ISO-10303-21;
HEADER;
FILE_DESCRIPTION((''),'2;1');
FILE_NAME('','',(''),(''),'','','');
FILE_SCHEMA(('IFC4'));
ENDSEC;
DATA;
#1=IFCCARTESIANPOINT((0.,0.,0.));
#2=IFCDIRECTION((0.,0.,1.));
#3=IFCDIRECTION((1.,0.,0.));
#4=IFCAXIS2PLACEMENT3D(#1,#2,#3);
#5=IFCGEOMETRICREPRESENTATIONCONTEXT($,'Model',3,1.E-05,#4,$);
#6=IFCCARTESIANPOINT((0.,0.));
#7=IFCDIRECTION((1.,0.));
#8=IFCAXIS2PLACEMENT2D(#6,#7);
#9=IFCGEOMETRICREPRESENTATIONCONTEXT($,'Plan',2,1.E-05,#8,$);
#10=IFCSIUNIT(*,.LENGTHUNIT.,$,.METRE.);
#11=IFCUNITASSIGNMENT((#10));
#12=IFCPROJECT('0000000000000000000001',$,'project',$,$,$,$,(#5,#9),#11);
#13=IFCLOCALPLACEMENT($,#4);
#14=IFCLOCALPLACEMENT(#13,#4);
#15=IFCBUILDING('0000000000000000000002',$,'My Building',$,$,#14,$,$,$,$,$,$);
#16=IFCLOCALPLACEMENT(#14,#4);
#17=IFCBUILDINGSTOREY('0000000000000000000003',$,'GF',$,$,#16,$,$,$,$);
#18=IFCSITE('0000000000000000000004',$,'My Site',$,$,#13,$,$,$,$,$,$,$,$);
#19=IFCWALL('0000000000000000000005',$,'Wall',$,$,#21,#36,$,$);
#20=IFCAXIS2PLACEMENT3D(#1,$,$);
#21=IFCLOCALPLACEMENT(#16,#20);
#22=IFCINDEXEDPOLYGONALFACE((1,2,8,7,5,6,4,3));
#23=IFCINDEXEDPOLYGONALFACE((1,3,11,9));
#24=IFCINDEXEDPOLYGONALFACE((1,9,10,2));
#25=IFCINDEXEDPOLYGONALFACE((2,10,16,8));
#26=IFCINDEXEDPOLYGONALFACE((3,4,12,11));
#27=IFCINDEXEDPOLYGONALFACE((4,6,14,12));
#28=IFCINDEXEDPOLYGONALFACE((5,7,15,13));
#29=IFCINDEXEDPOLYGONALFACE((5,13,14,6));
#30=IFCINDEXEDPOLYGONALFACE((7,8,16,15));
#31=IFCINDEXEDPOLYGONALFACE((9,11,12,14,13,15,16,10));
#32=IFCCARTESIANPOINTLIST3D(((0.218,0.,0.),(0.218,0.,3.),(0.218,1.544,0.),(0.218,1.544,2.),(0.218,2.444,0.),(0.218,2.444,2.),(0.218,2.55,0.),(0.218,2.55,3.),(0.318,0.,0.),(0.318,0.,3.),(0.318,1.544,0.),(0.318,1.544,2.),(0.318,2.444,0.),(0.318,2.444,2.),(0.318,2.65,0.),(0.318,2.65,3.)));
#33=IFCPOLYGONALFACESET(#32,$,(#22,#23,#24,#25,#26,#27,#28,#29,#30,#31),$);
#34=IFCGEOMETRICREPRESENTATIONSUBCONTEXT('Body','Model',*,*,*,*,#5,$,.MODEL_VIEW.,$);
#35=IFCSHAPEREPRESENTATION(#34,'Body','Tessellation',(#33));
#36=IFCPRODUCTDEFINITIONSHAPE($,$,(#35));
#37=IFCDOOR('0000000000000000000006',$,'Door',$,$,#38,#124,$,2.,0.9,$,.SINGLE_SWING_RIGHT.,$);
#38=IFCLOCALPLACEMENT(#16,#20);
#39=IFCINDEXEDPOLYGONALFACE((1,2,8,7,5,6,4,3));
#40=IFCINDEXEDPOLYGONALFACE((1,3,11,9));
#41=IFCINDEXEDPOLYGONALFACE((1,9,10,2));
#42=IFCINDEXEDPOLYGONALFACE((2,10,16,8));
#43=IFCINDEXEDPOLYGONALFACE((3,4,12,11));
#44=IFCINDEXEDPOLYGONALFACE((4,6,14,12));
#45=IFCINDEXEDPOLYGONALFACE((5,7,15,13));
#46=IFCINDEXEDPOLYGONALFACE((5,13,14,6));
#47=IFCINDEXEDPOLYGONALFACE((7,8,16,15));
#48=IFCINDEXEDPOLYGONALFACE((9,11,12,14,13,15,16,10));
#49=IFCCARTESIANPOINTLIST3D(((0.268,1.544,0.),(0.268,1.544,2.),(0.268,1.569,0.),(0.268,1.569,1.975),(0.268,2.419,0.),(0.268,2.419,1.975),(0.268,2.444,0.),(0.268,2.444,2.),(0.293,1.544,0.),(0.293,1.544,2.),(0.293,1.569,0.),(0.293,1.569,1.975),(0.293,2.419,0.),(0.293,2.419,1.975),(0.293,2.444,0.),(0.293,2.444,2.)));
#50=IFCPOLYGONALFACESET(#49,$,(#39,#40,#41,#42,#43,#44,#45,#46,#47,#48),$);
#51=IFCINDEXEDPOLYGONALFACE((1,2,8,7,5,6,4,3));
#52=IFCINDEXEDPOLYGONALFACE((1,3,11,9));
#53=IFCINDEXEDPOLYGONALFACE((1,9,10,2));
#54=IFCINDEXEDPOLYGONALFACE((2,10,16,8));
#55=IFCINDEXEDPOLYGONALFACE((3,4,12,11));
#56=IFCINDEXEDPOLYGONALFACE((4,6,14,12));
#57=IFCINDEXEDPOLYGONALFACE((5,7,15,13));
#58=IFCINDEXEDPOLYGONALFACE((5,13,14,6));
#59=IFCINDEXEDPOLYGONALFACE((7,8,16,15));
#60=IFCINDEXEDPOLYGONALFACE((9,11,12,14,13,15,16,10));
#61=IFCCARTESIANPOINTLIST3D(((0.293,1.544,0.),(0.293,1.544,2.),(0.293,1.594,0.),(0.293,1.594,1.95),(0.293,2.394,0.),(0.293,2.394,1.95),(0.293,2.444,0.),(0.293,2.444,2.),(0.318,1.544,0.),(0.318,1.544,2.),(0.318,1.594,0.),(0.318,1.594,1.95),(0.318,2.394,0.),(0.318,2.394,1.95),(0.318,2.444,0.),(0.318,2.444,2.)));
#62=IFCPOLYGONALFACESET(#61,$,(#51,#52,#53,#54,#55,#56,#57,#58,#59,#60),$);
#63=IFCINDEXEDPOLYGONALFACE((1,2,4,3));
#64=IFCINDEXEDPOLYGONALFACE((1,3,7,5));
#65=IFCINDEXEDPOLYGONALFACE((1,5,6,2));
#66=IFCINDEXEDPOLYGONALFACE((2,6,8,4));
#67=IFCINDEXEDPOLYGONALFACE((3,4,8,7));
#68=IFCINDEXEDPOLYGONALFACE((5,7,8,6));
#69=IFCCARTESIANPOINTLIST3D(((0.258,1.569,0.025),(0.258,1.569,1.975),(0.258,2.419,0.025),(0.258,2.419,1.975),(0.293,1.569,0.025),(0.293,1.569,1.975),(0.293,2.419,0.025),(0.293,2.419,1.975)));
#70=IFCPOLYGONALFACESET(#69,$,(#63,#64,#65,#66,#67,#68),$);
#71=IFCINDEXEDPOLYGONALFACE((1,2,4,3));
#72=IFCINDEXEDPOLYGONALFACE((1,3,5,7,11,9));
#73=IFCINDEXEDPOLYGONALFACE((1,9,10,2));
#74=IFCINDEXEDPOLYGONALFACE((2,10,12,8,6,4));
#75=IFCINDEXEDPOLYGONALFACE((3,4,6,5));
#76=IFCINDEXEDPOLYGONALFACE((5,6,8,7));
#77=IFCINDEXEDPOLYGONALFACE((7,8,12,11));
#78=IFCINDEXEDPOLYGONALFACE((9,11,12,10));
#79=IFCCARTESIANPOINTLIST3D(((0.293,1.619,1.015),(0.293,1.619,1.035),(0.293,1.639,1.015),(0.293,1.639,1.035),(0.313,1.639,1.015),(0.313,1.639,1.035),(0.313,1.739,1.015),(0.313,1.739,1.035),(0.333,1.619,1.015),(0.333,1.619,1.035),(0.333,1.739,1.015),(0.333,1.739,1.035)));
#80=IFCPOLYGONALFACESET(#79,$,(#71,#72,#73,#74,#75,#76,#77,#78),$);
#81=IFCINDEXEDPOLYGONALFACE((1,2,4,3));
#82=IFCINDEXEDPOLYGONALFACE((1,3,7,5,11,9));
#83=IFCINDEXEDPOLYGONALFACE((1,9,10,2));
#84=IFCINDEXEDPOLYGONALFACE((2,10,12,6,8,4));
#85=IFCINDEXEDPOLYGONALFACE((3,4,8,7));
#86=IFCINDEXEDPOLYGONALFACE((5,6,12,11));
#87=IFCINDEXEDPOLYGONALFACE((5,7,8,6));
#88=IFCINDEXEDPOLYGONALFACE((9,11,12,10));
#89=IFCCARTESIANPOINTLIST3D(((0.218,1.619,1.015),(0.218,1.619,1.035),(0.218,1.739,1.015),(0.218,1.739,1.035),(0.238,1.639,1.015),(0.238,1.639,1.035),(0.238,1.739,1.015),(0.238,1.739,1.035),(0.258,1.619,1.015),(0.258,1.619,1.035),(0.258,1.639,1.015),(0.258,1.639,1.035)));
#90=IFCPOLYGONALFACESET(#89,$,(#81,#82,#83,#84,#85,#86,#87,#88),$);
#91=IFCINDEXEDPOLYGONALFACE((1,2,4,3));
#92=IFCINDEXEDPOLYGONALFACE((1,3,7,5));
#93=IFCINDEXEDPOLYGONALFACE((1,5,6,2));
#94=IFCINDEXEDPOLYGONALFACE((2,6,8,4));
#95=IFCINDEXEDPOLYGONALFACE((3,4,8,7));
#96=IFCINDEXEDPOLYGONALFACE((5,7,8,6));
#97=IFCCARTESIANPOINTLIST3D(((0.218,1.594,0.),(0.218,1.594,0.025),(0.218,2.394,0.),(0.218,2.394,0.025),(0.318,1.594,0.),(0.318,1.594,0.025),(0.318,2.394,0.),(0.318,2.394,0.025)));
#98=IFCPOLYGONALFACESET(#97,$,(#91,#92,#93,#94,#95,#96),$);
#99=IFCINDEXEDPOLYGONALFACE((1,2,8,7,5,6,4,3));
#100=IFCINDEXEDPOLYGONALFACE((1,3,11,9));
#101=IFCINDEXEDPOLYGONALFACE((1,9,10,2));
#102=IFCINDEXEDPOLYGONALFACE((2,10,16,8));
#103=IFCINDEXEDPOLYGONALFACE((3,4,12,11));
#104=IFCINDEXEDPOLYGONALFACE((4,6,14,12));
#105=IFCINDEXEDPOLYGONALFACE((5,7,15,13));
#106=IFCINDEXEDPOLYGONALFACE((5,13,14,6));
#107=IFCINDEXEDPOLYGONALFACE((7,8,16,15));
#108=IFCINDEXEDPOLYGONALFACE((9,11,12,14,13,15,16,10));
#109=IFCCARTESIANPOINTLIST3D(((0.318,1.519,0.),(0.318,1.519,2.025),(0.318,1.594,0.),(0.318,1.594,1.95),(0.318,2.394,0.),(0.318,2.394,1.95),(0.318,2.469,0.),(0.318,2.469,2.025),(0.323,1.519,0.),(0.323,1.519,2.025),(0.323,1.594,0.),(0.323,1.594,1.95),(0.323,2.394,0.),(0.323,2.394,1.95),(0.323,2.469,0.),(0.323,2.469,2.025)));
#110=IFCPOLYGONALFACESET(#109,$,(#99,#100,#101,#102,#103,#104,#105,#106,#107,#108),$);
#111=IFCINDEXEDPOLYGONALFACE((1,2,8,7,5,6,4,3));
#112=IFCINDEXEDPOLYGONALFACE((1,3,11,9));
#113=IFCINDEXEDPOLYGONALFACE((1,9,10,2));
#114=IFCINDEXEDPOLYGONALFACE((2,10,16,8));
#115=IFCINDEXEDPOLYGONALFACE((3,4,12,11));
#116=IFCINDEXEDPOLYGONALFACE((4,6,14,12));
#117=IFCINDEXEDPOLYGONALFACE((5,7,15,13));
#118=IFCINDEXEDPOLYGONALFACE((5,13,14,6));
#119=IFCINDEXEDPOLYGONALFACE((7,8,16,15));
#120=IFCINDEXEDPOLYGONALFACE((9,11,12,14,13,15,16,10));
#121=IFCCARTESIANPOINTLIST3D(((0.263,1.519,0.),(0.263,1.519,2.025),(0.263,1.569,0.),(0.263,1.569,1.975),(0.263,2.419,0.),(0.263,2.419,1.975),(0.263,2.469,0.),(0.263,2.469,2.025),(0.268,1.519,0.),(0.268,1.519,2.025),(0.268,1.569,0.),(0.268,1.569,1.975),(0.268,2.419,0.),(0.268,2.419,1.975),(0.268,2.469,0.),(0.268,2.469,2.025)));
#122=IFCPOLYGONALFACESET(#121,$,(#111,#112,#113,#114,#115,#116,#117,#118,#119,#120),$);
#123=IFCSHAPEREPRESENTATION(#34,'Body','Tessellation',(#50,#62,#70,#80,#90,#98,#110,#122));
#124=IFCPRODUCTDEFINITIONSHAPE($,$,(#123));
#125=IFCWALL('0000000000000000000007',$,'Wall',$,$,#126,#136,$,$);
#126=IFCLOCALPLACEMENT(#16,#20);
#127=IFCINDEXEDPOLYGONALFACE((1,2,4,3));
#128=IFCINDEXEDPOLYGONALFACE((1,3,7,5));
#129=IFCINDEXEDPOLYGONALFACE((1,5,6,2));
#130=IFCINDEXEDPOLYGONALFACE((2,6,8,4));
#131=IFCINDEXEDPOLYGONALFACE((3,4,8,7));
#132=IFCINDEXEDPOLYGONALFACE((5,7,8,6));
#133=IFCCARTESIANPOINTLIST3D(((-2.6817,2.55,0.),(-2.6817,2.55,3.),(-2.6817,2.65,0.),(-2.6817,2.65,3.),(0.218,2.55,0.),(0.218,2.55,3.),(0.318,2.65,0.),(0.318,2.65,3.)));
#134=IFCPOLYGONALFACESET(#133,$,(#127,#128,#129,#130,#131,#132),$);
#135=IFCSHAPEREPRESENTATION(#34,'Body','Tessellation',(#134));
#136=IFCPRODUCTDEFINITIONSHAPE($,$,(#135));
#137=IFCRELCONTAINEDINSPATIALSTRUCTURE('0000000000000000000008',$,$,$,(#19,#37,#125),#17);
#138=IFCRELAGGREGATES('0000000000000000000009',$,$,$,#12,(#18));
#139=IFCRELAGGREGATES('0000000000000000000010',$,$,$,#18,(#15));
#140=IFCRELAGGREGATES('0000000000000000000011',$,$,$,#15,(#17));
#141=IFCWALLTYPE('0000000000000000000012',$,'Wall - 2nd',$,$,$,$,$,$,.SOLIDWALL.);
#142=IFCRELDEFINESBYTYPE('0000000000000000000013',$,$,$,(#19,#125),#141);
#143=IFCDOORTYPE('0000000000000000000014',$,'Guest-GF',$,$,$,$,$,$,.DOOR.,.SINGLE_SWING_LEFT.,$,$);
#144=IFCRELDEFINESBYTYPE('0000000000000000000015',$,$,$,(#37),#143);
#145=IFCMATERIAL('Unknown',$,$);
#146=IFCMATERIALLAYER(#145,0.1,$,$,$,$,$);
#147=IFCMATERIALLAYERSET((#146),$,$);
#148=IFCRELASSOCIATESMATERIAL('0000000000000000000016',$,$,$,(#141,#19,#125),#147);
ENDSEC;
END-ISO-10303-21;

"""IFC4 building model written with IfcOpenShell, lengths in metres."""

from ifc_helpers import new_model, entity, si_unit, frame, origin_with_axes, origin_2d_with_axis, place, context, subcontext, project, spatial, line, indexed_curve, outline, extrude, shape, source, transform, mapped, material, layer, layer_set, layer_usage, type_object, type_shapes, element, fill, save


model = new_model("IFC4")

# Units and contexts
model_context = context("Model", 3, precision=1e-05, world=origin_with_axes())
plan_context = context("Plan", 2, precision=1e-05, world=origin_2d_with_axis())
body_context_1 = subcontext(model_context, "Body", "Model", "MODEL_VIEW")
body_context_2 = subcontext(plan_context, "Body", "Plan", "PLAN_VIEW")
ifc_project = project(units=[si_unit("LENGTHUNIT", "METRE")], contexts=[model_context, plan_context])

# Site, building, storey
site_placement = place(None, origin_with_axes())
site = spatial("IfcSite", under=ifc_project, at=site_placement, Name="My Site")
building_placement = place(site_placement, origin_with_axes())
building = spatial("IfcBuilding", under=site, at=building_placement, Name="My Building")
storey_placement = place(building_placement, origin_with_axes())
storey = spatial("IfcBuildingStorey", under=building, at=storey_placement, Name="GF")

# Shared definitions
ifc_material = material(Name="Unknown")

# Shared definitions
ifc_layer_1 = layer(ifc_material, 0.1)
ifc_layer_set_1 = layer_set([ifc_layer_1])
wall_type = type_object("IfcWallType", Name="Wall - 2nd", PredefinedType="SOLIDWALL", material=ifc_layer_set_1)

# Wall, opening, door
ifc_layer_usage_1 = layer_usage(ifc_layer_set_1, "AXIS2", "POSITIVE", 0.0)
wall_1_placement = place(storey_placement, frame((0.318, 0.0, 0.0), z_axis=(0.0, 0.0, 1.0), x_axis=(0.0, 1.0, 0.0)))
wall_1 = element("IfcWall", 1, at=wall_1_placement, inside=storey, type_object=wall_type, material=ifc_layer_usage_1, Name="Wall", context=body_context_1, shape_type="SweptSolid", body=[
    extrude(outline(indexed_curve([(0.0, 0.0), (0.0, 0.1), (2.55, 0.1), (2.65, 0.0)], segments=[line(1, 2, 3, 4, 1)])), origin_with_axes(), (0.0, 0.0, 1.0), 3.0),
])
shared_shape_1 = source(origin_with_axes(), body_context_1, "Body", "SweptSolid", [
    extrude(outline(indexed_curve([(0.0, 0.0), (0.9, 0.0), (0.9, 2.0), (0.0, 2.0)], segments=[line(1, 2, 3, 4, 1)])), frame((0.0, -0.6, 0.0), z_axis=(0.0, -1.0, 0.0), x_axis=(1.0, 0.0, 0.0)), (0.0, 0.0, -1.0), 1.2),
])
opening_1_placement = place(wall_1_placement, frame((1.544, 0.0, 0.0), z_axis=(0.0, 0.0, 1.0), x_axis=(1.0, 0.0, 0.0)))
opening_1 = element("IfcOpeningElement", 2, at=opening_1_placement, cuts=wall_1, PredefinedType="OPENING", context=body_context_1, shape_type="MappedRepresentation", body=[
    mapped(shared_shape_1, transform((0.0, 0.0, 0.0), x_axis=(1.0, 0.0, 0.0), y_axis=(0.0, 1.0, 0.0), z_axis=(0.0, 0.0, 1.0), scale=1.0)),
])
door_type_1 = type_object("IfcDoorType", Name="Guest-GF", OperationType="SINGLE_SWING_LEFT", PredefinedType="DOOR")
shared_shape_2 = source(origin_with_axes(), body_context_1, "Body", "SweptSolid", [
    extrude(outline(indexed_curve([(0.0, 0.0), (0.0, 2.0), (0.9, 2.0), (0.9, 0.0), (0.875, 0.0), (0.875, 1.975), (0.025, 1.975), (0.025, 0.0)], segments=[line(1, 2, 3, 4, 5, 6, 7, 8, 1)])), frame((0.0, 0.025, 0.0), z_axis=(0.0, -1.0, 0.0), x_axis=(1.0, 0.0, 0.0)), (0.0, 0.0, -1.0), 0.025),
    extrude(outline(indexed_curve([(0.0, 0.0), (0.0, 2.0), (0.9, 2.0), (0.9, 0.0), (0.85, 0.0), (0.85, 1.95), (0.05, 1.95), (0.05, 0.0)], segments=[line(1, 2, 3, 4, 5, 6, 7, 8, 1)])), frame((0.0, 0.0, 0.0), z_axis=(0.0, -1.0, 0.0), x_axis=(1.0, 0.0, 0.0)), (0.0, 0.0, -1.0), 0.025),
    extrude(outline(indexed_curve([(0.0, 0.0), (0.85, 0.0), (0.85, 0.035), (0.0, 0.035)], segments=[line(1, 2, 3, 4, 1)])), frame((0.025, 0.025, 0.025), z_axis=(0.0, 0.0, 1.0), x_axis=(1.0, 0.0, 0.0)), (0.0, 0.0, 1.0), 1.95),
    extrude(outline(indexed_curve([(0.0, 0.0), (0.0, -0.04), (0.12, -0.04), (0.12, -0.02), (0.02, -0.02), (0.02, 0.0)], segments=[line(1, 2, 3, 4, 5, 6, 1)])), frame((0.075, 0.025, 1.015), z_axis=(0.0, 0.0, 1.0), x_axis=(1.0, 0.0, 0.0)), (0.0, 0.0, 1.0), 0.02),
    extrude(outline(indexed_curve([(0.0, 0.0), (0.0, 0.04), (0.12, 0.04), (0.12, 0.02), (0.02, 0.02), (0.02, 0.0)], segments=[line(1, 2, 3, 4, 5, 6, 1)])), frame((0.075, 0.06, 1.015), z_axis=(0.0, 0.0, 1.0), x_axis=(1.0, 0.0, 0.0)), (0.0, 0.0, 1.0), 0.02),
    extrude(outline(indexed_curve([(0.0, 0.0), (0.8, 0.0), (0.8, 0.1), (0.0, 0.1)], segments=[line(1, 2, 3, 4, 1)])), frame((0.05, 0.0, 0.0), z_axis=(0.0, 0.0, 1.0), x_axis=(1.0, 0.0, 0.0)), (0.0, 0.0, 1.0), 0.025),
    extrude(outline(indexed_curve([(0.0, 0.0), (0.0, 2.025), (0.95, 2.025), (0.95, 0.0), (0.875, 0.0), (0.875, 1.95), (0.075, 1.95), (0.075, 0.0)], segments=[line(1, 2, 3, 4, 5, 6, 7, 8, 1)])), frame((-0.025, -0.005, 0.0), z_axis=(0.0, -1.0, 0.0), x_axis=(1.0, 0.0, 0.0)), (0.0, 0.0, -1.0), 0.005),
    extrude(outline(indexed_curve([(0.0, 0.0), (0.0, 2.025), (0.95, 2.025), (0.95, 0.0), (0.9, 0.0), (0.9, 1.975), (0.05, 1.975), (0.05, 0.0)], segments=[line(1, 2, 3, 4, 5, 6, 7, 8, 1)])), frame((-0.025, 0.05, 0.0), z_axis=(0.0, -1.0, 0.0), x_axis=(1.0, 0.0, 0.0)), (0.0, 0.0, -1.0), 0.005),
])
shared_shape_3 = source(origin_with_axes(), body_context_2, "Body", "Curve2D", [
    entity("IfcIndexedPolyCurve", entity("IfcCartesianPointList2D", [[0.0, 0.0], [0.0, 0.05], [0.025, 0.05], [0.025, 0.025], [0.05, 0.025], [0.05, 0.0]]), [entity("IfcLineIndex", [1, 2, 3, 4, 5, 6, 1])]),
    entity("IfcIndexedPolyCurve", entity("IfcCartesianPointList2D", [[0.9, 0.0], [0.9, 0.05], [0.875, 0.05], [0.875, 0.025], [0.85, 0.025], [0.85, 0.0]]), [entity("IfcLineIndex", [1, 2, 3, 4, 5, 6, 1])]),
    entity("IfcTrimmedCurve", entity("IfcEllipse", entity("IfcAxis2Placement2D", entity("IfcCartesianPoint", [0.84, 0.05]), entity("IfcDirection", [1.0, 0.0])), 0.815, 0.85), [entity("IfcCartesianPoint", [0.84, 0.9])], [entity("IfcCartesianPoint", [0.025, 0.05])], True, "CARTESIAN"),
    entity("IfcIndexedPolyCurve", entity("IfcCartesianPointList2D", [[0.875, 0.05], [0.84, 0.05], [0.84, 0.9], [0.875, 0.9]]), [entity("IfcLineIndex", [1, 2, 3, 4, 1])]),
])
type_shapes(door_type_1, [shared_shape_2, shared_shape_3])
door_1_placement = place(opening_1_placement, frame((0.0, 0.0, 0.0), z_axis=(0.0, 0.0, 1.0), x_axis=(1.0, 0.0, 0.0)))
door_1 = element("IfcDoor", 3, at=door_1_placement, inside=storey, type_object=door_type_1, Name="Door", OperationType="SINGLE_SWING_RIGHT", OverallHeight=2.0, OverallWidth=0.9, shapes=[
    shape(body_context_1, "Body", "MappedRepresentation", [mapped(shared_shape_2, transform((0.0, 0.0, 0.0), x_axis=(1.0, 0.0, 0.0), y_axis=(0.0, 1.0, 0.0), z_axis=(0.0, 0.0, 1.0), scale=1.0))]),
    shape(body_context_2, "Body", "MappedRepresentation", [mapped(shared_shape_3, transform((0.0, 0.0, 0.0), x_axis=(1.0, 0.0, 0.0), y_axis=(0.0, 1.0, 0.0), z_axis=(0.0, 0.0, 1.0), scale=1.0))]),
])
fill(opening_1, door_1)

# Wall
ifc_layer_usage_2 = layer_usage(ifc_layer_set_1, "AXIS2", "POSITIVE", 0.0)
wall_2_placement = place(storey_placement, frame((0.318, 2.65, 0.0), z_axis=(0.0, 0.0, 1.0), x_axis=(-1.0, 0.0, 0.0)))
element("IfcWall", 4, at=wall_2_placement, inside=storey, type_object=wall_type, material=ifc_layer_usage_2, Name="Wall", context=body_context_1, shape_type="SweptSolid", body=[
    extrude(outline(indexed_curve([(0.0, 0.0), (0.1, 0.1), (2.9996, 0.1), (2.9996, 0.0)], segments=[line(1, 2, 3, 4, 1)])), origin_with_axes(), (0.0, 0.0, 1.0), 3.0),
])

save(model, "model.ifc")
